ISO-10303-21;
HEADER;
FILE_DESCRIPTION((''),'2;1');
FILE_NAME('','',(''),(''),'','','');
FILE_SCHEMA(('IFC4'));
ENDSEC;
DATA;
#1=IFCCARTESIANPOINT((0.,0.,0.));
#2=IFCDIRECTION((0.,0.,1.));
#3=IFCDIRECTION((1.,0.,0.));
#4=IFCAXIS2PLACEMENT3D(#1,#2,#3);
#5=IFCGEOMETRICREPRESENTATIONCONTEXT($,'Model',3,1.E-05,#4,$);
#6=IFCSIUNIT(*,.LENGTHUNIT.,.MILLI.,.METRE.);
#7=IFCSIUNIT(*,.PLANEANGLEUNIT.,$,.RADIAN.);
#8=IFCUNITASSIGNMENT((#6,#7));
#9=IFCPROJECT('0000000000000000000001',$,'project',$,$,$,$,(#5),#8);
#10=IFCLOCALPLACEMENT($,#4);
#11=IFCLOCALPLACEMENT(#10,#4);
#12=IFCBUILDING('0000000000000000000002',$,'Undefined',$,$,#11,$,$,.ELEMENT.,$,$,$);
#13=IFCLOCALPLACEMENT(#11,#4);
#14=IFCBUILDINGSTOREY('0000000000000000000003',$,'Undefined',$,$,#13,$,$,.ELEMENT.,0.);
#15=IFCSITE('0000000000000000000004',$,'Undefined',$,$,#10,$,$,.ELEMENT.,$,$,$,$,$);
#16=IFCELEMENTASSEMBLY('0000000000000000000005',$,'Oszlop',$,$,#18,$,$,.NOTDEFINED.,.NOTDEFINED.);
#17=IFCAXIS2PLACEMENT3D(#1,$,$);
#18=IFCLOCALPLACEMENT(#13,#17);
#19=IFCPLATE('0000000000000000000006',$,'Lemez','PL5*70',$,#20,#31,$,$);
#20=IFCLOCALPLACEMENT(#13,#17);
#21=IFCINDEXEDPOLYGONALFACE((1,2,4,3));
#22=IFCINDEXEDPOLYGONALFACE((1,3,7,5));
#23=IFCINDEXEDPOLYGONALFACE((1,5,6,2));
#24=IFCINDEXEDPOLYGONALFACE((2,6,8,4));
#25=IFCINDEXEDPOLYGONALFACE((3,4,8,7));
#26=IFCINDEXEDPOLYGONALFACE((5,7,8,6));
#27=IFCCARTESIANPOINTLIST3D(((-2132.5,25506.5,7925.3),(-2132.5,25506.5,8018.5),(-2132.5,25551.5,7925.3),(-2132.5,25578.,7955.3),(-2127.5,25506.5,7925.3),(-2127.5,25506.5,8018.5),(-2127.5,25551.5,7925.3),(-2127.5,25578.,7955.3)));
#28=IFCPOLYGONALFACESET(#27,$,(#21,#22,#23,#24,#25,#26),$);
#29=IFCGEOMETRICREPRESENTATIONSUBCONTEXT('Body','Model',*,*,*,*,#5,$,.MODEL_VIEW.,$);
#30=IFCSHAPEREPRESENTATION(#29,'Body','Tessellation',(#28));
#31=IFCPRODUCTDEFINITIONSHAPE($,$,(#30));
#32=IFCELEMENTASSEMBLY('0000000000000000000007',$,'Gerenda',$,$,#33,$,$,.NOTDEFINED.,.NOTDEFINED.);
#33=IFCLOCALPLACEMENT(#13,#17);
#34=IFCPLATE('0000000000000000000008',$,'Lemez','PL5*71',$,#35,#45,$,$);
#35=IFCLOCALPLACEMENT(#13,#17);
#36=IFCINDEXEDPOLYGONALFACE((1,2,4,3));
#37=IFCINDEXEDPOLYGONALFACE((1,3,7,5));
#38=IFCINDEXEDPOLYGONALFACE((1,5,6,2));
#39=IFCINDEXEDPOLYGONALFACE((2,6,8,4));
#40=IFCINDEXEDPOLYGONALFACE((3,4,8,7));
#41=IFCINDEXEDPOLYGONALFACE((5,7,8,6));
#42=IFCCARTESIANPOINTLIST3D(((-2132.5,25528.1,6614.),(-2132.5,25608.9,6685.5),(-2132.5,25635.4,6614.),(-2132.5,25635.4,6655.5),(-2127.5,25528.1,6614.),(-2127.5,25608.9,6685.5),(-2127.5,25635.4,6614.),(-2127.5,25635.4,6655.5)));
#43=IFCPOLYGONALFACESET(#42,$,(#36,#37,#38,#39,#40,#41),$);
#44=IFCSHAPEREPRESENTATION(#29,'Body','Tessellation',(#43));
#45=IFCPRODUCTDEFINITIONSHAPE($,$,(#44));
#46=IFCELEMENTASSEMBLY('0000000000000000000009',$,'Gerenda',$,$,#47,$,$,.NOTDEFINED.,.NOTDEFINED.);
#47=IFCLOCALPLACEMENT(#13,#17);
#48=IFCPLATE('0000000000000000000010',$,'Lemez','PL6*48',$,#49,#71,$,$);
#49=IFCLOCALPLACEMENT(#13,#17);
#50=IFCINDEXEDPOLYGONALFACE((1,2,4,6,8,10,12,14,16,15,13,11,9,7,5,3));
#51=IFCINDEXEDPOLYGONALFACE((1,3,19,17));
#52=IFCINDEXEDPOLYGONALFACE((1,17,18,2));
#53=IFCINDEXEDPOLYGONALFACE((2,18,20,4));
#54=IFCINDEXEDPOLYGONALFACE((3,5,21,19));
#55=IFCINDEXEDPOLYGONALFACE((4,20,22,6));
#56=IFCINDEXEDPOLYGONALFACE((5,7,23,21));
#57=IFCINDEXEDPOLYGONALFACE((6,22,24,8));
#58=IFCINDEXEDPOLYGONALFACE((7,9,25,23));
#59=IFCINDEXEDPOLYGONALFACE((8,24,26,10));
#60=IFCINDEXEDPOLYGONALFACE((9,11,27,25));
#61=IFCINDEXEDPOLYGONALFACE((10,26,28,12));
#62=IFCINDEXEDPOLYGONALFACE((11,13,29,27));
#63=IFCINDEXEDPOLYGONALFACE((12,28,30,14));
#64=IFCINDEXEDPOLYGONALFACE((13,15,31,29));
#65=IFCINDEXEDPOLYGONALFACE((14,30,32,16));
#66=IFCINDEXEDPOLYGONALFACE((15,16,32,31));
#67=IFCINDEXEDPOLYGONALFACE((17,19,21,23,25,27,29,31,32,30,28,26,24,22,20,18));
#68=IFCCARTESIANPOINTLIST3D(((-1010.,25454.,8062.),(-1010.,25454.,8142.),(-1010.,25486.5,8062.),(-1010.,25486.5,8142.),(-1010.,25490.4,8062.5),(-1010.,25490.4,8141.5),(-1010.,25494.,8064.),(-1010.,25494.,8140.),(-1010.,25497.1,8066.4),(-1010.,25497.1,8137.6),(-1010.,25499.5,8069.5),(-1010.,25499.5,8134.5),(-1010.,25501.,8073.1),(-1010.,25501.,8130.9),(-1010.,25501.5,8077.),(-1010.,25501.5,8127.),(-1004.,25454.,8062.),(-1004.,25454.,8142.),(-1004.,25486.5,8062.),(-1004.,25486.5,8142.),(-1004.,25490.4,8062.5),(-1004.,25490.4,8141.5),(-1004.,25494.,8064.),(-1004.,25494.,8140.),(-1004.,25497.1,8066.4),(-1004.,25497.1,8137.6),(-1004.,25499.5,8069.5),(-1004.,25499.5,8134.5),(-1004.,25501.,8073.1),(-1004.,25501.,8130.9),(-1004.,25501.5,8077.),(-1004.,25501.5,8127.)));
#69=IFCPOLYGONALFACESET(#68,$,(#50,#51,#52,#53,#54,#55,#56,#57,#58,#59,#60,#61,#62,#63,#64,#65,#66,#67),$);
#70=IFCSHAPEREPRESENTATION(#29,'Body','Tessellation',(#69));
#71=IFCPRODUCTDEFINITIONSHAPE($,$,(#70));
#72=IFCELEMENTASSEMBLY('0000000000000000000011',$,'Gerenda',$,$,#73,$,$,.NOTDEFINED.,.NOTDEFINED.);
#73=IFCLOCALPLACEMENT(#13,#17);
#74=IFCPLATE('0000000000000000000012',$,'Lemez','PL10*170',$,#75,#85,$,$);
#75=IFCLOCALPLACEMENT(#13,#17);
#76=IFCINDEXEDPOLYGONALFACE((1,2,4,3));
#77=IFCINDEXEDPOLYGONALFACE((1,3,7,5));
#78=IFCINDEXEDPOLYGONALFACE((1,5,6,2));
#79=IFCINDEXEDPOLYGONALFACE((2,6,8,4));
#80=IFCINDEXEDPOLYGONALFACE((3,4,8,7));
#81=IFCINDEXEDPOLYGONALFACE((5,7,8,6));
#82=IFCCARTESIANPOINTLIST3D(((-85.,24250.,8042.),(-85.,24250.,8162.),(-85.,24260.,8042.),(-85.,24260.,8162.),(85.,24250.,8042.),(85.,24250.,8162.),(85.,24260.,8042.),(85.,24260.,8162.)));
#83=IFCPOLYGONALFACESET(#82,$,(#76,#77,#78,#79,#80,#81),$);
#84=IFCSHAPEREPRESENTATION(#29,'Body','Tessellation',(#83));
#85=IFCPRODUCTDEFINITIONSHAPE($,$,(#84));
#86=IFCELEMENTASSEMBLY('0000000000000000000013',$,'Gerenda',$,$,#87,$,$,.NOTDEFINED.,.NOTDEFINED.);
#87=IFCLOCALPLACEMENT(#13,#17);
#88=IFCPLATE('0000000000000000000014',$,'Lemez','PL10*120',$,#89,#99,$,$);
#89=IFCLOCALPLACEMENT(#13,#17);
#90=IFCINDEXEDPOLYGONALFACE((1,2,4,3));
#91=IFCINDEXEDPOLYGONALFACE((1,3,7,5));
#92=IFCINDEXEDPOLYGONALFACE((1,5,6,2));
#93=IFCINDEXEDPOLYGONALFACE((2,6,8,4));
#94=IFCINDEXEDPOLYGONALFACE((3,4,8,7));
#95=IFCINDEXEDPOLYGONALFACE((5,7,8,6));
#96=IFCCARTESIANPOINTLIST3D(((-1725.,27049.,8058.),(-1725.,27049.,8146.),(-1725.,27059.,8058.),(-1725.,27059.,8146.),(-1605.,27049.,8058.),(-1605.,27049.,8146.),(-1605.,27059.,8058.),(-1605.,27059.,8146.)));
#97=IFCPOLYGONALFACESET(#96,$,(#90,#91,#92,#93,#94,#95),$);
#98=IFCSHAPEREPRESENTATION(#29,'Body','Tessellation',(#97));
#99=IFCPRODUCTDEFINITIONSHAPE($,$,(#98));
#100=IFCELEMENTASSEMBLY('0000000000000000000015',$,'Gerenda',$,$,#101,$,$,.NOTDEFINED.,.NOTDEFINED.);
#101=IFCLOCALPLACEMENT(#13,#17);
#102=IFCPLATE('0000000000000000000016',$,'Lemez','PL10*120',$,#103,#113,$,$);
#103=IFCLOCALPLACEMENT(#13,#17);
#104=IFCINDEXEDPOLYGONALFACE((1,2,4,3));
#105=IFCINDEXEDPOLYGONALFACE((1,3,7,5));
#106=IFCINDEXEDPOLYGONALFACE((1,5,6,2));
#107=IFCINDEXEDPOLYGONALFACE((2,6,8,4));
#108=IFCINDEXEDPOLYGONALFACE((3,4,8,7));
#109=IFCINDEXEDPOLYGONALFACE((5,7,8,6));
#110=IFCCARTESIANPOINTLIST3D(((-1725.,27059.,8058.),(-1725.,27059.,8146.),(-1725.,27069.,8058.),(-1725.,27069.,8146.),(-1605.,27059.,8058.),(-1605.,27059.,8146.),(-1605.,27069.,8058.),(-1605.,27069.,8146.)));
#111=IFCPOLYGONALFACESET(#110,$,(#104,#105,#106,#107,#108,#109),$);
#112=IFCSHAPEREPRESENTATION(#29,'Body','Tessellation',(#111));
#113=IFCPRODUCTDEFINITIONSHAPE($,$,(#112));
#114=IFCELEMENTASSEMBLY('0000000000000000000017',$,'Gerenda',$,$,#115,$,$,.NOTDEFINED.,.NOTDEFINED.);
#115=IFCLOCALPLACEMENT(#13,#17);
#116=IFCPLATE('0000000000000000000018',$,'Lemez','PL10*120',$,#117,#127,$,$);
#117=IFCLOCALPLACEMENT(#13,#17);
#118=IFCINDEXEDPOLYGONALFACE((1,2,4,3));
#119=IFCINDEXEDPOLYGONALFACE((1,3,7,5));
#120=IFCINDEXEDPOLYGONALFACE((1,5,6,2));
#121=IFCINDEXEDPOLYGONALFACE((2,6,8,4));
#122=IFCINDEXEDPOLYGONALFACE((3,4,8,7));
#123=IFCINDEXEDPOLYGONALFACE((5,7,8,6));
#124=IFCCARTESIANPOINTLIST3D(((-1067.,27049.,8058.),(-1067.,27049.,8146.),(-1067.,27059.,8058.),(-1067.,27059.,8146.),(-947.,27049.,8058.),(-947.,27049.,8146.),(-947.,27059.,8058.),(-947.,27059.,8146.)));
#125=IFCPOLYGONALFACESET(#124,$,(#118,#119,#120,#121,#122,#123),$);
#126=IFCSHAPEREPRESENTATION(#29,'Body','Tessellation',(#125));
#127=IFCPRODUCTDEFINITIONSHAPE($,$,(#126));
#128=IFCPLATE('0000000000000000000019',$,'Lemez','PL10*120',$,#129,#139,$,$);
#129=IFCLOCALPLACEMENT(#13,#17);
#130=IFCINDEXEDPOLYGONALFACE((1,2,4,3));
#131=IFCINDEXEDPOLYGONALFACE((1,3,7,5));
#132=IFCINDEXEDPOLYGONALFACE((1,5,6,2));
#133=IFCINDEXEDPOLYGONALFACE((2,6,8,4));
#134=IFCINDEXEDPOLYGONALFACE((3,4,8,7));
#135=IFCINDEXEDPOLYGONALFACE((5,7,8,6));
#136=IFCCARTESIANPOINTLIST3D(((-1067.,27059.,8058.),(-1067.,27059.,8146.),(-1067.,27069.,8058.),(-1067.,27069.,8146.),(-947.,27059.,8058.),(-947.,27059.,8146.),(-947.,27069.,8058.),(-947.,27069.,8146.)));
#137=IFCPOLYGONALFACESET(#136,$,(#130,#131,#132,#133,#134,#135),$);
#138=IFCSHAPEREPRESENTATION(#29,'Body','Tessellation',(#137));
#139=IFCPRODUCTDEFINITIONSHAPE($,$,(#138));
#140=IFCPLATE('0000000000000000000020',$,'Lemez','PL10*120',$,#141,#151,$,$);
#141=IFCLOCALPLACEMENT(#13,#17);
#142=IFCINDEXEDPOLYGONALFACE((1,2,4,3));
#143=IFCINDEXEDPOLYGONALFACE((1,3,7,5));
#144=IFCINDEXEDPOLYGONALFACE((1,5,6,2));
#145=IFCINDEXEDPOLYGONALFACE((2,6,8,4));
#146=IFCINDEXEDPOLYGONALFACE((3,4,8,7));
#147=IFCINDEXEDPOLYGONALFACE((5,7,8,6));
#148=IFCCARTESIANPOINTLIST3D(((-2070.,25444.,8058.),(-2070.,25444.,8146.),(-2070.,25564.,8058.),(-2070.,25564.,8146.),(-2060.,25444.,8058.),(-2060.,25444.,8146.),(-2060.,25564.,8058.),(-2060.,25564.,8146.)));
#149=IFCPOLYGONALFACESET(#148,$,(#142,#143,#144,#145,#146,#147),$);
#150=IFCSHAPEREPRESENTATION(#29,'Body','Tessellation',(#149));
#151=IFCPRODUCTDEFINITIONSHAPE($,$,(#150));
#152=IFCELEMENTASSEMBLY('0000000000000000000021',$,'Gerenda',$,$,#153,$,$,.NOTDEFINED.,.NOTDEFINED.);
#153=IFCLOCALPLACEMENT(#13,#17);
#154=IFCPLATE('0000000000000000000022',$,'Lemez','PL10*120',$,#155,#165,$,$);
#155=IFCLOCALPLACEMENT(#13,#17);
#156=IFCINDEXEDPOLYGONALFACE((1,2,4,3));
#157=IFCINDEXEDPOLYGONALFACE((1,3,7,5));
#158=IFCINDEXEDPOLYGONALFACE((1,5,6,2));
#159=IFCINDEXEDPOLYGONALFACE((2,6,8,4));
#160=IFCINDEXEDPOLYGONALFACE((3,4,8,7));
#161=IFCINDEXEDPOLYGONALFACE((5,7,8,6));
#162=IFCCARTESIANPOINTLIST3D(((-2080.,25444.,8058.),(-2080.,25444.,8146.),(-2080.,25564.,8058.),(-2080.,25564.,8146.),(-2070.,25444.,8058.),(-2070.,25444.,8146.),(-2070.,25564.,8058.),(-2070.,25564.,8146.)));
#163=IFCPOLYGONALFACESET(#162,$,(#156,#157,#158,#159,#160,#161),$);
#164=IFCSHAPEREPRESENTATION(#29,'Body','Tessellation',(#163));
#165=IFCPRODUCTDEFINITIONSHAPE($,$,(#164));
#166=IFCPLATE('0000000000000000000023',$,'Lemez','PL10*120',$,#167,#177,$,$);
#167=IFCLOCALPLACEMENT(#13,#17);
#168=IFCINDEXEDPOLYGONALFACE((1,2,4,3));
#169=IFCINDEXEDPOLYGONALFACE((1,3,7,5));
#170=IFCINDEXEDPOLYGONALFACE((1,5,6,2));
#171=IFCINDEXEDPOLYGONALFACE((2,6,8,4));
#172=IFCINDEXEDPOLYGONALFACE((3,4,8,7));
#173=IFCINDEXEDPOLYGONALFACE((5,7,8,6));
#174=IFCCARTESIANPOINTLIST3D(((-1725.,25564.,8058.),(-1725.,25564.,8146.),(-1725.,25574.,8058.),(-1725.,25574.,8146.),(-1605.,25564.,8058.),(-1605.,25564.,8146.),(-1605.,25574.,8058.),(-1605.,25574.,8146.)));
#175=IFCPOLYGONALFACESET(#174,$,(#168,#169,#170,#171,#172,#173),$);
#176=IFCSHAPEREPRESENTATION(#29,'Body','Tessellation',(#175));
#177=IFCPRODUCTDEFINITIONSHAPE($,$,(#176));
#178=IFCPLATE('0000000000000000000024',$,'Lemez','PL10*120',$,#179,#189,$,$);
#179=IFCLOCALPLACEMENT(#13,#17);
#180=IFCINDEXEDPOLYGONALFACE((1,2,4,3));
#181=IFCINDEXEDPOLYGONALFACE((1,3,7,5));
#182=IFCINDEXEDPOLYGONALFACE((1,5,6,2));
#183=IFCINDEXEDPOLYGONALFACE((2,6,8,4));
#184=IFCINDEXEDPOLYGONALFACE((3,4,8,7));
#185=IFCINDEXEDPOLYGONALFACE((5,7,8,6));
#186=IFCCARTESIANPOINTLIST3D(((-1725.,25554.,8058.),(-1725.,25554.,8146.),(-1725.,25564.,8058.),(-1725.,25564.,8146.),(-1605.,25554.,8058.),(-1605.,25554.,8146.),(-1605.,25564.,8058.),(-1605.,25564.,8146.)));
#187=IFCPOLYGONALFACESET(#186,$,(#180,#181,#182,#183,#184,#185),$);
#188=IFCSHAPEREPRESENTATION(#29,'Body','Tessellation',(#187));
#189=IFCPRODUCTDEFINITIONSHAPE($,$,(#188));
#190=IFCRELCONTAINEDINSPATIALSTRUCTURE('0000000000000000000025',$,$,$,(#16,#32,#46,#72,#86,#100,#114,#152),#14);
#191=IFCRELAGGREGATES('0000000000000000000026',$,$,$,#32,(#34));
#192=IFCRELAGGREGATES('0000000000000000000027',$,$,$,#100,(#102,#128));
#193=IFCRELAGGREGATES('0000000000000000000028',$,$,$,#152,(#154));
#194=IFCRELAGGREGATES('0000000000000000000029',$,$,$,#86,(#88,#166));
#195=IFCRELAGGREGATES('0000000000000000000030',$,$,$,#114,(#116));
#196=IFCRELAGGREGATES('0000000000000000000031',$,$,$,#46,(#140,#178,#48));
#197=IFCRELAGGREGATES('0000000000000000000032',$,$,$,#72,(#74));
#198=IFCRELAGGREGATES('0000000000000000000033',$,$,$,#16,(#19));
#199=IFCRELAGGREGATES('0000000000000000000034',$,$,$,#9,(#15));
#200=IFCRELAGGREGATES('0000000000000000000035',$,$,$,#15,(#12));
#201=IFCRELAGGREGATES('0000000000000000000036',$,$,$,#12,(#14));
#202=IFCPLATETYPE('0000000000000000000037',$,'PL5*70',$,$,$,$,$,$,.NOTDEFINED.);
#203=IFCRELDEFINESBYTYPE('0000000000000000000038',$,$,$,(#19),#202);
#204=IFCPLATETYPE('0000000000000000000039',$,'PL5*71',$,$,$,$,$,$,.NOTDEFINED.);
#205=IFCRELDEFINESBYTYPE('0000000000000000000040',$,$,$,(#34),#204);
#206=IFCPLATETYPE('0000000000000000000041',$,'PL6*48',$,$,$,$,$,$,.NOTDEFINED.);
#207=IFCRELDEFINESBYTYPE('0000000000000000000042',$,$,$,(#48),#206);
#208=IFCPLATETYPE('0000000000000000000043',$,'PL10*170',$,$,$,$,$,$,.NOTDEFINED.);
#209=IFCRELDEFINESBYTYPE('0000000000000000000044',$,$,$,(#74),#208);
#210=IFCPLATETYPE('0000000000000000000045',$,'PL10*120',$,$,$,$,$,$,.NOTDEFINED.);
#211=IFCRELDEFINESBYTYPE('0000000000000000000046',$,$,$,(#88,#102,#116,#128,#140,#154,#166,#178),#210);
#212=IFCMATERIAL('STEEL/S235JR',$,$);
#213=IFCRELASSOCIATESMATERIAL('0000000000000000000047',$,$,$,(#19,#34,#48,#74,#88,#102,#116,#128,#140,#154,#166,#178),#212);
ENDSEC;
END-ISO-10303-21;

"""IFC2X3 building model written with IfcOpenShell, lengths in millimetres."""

from ifc_helpers import new_model, si_unit, frame, frame_2d, origin_with_axes, place, context, subcontext, project, spatial, polyline, circle_curve, parameter, trimmed, segment, composite_curve, outline, extrude, material, type_object, element, aggregate, save


model = new_model("IFC2X3")

# Units and contexts
model_context = context("Model", 3, precision=1e-05, world=origin_with_axes())
body_context = subcontext(model_context, "Body", "Model", "MODEL_VIEW")
ifc_project = project(units=[si_unit("LENGTHUNIT", "METRE", prefix="MILLI"), si_unit("PLANEANGLEUNIT", "RADIAN")], contexts=[model_context])

# Site, building, storey
site_placement = place(None, origin_with_axes())
site = spatial("IfcSite", under=ifc_project, at=site_placement, Name="Undefined", CompositionType="ELEMENT")
building_placement = place(site_placement, origin_with_axes())
building = spatial("IfcBuilding", under=site, at=building_placement, Name="Undefined", CompositionType="ELEMENT")
storey_placement = place(building_placement, origin_with_axes())
storey = spatial("IfcBuildingStorey", under=building, at=storey_placement, Name="Undefined", CompositionType="ELEMENT", Elevation=0.0)

# Shared definitions
ifc_material_1 = material(Name="STEEL/S235JR")

# Element assemblies, plates
assembly_1_placement = place(storey_placement, origin_with_axes())
assembly_1 = element("IfcElementAssembly", 1, at=assembly_1_placement, inside=storey, Name="Oszlop", AssemblyPlace="NOTDEFINED", PredefinedType="NOTDEFINED")
plate_type_1 = type_object("IfcPlateType", Name="PL5*70", PredefinedType="NOTDEFINED")
plate_1_placement = place(assembly_1_placement, frame((-2130.0, 25506.5, 7925.3), z_axis=(-1.0, -0.000005, 0.0), x_axis=(0.0, 0.0, 1.0)))
plate_1 = element("IfcPlate", 2, at=plate_1_placement, type_object=plate_type_1, material=ifc_material_1, Name="Lemez", Description="PL5*70", context=body_context, shape_type="SweptSolid", body=[
    extrude(outline(polyline([(0.0, 0.0), (93.2, 0.0), (30.0, 71.5), (0.0, 45.0), (0.0, 0.0)])), frame((0.0, 0.0, -2.5), z_axis=(0.0, 0.0, 1.0), x_axis=(1.0, 0.0, 0.0)), (0.0, 0.0, 1.0), 5.0),
])
assembly_2_placement = place(storey_placement, origin_with_axes())
assembly_2 = element("IfcElementAssembly", 3, at=assembly_2_placement, inside=storey, Name="Gerenda", AssemblyPlace="NOTDEFINED", PredefinedType="NOTDEFINED")
plate_type_2 = type_object("IfcPlateType", Name="PL5*71", PredefinedType="NOTDEFINED")
plate_2_placement = place(assembly_2_placement, frame((-2130.0, 25528.1, 6614.0), z_axis=(1.0, -0.000003, -0.000002), x_axis=(0.000003, 1.0, 0.0)))
plate_2 = element("IfcPlate", 4, at=plate_2_placement, type_object=plate_type_2, material=ifc_material_1, Name="Lemez", Description="PL5*71", context=body_context, shape_type="SweptSolid", body=[
    extrude(outline(polyline([(0.0, 0.0), (107.3, 0.0), (107.3, 41.5), (80.8, 71.5), (0.0, 0.0)])), frame((0.0, 0.0, -2.5), z_axis=(0.0, 0.0, 1.0), x_axis=(1.0, 0.0, 0.0)), (0.0, 0.0, 1.0), 5.0),
])
aggregate(assembly_2, [plate_2])
assembly_3_placement = place(storey_placement, origin_with_axes())
assembly_3 = element("IfcElementAssembly", 5, at=assembly_3_placement, inside=storey, Name="Gerenda", AssemblyPlace="NOTDEFINED", PredefinedType="NOTDEFINED")
plate_type_3 = type_object("IfcPlateType", Name="PL6*48", PredefinedType="NOTDEFINED")
plate_3_placement = place(assembly_3_placement, frame((-1007.0, 25501.5, 8062.0), z_axis=(-1.0, 0.000003, 0.0), x_axis=(-0.000003, -1.0, 0.0)))
plate_3 = element("IfcPlate", 6, at=plate_3_placement, type_object=plate_type_3, material=ifc_material_1, Name="Lemez", Description="PL6*48", context=body_context, shape_type="SweptSolid", body=[
    extrude(outline(composite_curve([segment(trimmed(circle_curve(frame_2d((15.0, 15.0), x_axis=(-1.0, 0.0)), 15.0), [parameter(0.0)], [parameter(1.570796)], True, "PARAMETER"), True, "CONTINUOUS"), segment(polyline([(15.0, 0.0), (47.5, 0.0), (47.5, 80.0), (15.0, 80.0)]), True, "CONTINUOUS"), segment(trimmed(circle_curve(frame_2d((15.0, 65.0), x_axis=(0.0, 1.0)), 15.0), [parameter(0.0)], [parameter(1.570796)], True, "PARAMETER"), True, "CONTINUOUS"), segment(polyline([(0.0, 65.0), (0.0, 15.0)]), True, "CONTINUOUS")], self_intersect=True)), frame((0.0, 0.0, -3.0), z_axis=(0.0, 0.0, 1.0), x_axis=(1.0, 0.0, 0.0)), (0.0, 0.0, 1.0), 6.0),
])
assembly_4_placement = place(storey_placement, origin_with_axes())
assembly_4 = element("IfcElementAssembly", 7, at=assembly_4_placement, inside=storey, Name="Gerenda", AssemblyPlace="NOTDEFINED", PredefinedType="NOTDEFINED")
plate_type_4 = type_object("IfcPlateType", Name="PL10*170", PredefinedType="NOTDEFINED")
plate_4_placement = place(assembly_4_placement, frame((0.0, 24255.0, 8042.0), z_axis=(0.000003, 1.0, 0.0), x_axis=(0.0, 0.0, 1.0)))
plate_4 = element("IfcPlate", 8, at=plate_4_placement, type_object=plate_type_4, material=ifc_material_1, Name="Lemez", Description="PL10*170", context=body_context, shape_type="SweptSolid", body=[
    extrude(outline(polyline([(0.0, -85.0), (0.0, 85.0), (120.0, 85.0), (120.0, -85.0), (0.0, -85.0)])), frame((0.0, 0.0, -5.0), z_axis=(0.0, 0.0, 1.0), x_axis=(1.0, 0.0, 0.0)), (0.0, 0.0, 1.0), 10.0),
])
assembly_5_placement = place(storey_placement, origin_with_axes())
assembly_5 = element("IfcElementAssembly", 9, at=assembly_5_placement, inside=storey, Name="Gerenda", AssemblyPlace="NOTDEFINED", PredefinedType="NOTDEFINED")
plate_type_5 = type_object("IfcPlateType", Name="PL10*120", PredefinedType="NOTDEFINED")
plate_5_placement = place(assembly_5_placement, frame((-1665.0, 27054.0, 8058.0), z_axis=(-0.000003, -1.0, 0.0), x_axis=(0.0, 0.0, 1.0)))
plate_5 = element("IfcPlate", 10, at=plate_5_placement, type_object=plate_type_5, material=ifc_material_1, Name="Lemez", Description="PL10*120", context=body_context, shape_type="SweptSolid", body=[
    extrude(outline(polyline([(0.0, -60.0), (0.0, 60.0), (88.0, 60.0), (88.0, -60.0), (0.0, -60.0)])), frame((0.0, 0.0, -5.0), z_axis=(0.0, 0.0, 1.0), x_axis=(1.0, 0.0, 0.0)), (0.0, 0.0, 1.0), 10.0),
])
assembly_6_placement = place(storey_placement, origin_with_axes())
assembly_6 = element("IfcElementAssembly", 11, at=assembly_6_placement, inside=storey, Name="Gerenda", AssemblyPlace="NOTDEFINED", PredefinedType="NOTDEFINED")
plate_6_placement = place(assembly_6_placement, frame((-1665.0, 27064.0, 8058.0), z_axis=(-0.000003, -1.0, 0.0), x_axis=(0.0, 0.0, 1.0)))
plate_6 = element("IfcPlate", 12, at=plate_6_placement, type_object=plate_type_5, material=ifc_material_1, Name="Lemez", Description="PL10*120", context=body_context, shape_type="SweptSolid", body=[
    extrude(outline(polyline([(0.0, -60.0), (0.0, 60.0), (88.0, 60.0), (88.0, -60.0), (0.0, -60.0)])), frame((0.0, 0.0, -5.0), z_axis=(0.0, 0.0, 1.0), x_axis=(1.0, 0.0, 0.0)), (0.0, 0.0, 1.0), 10.0),
])
assembly_7_placement = place(storey_placement, origin_with_axes())
assembly_7 = element("IfcElementAssembly", 13, at=assembly_7_placement, inside=storey, Name="Gerenda", AssemblyPlace="NOTDEFINED", PredefinedType="NOTDEFINED")
plate_7_placement = place(assembly_7_placement, frame((-1007.0, 27054.0, 8058.0), z_axis=(-0.000003, -1.0, 0.0), x_axis=(0.0, 0.0, 1.0)))
plate_7 = element("IfcPlate", 14, at=plate_7_placement, type_object=plate_type_5, material=ifc_material_1, Name="Lemez", Description="PL10*120", context=body_context, shape_type="SweptSolid", body=[
    extrude(outline(polyline([(0.0, -60.0), (0.0, 60.0), (88.0, 60.0), (88.0, -60.0), (0.0, -60.0)])), frame((0.0, 0.0, -5.0), z_axis=(0.0, 0.0, 1.0), x_axis=(1.0, 0.0, 0.0)), (0.0, 0.0, 1.0), 10.0),
])

# Plates
plate_8_placement = place(assembly_6_placement, frame((-1007.0, 27064.0, 8058.0), z_axis=(-0.000003, -1.0, 0.0), x_axis=(0.0, 0.0, 1.0)))
plate_8 = element("IfcPlate", 15, at=plate_8_placement, type_object=plate_type_5, material=ifc_material_1, Name="Lemez", Description="PL10*120", context=body_context, shape_type="SweptSolid", body=[
    extrude(outline(polyline([(0.0, -60.0), (0.0, 60.0), (88.0, 60.0), (88.0, -60.0), (0.0, -60.0)])), frame((0.0, 0.0, -5.0), z_axis=(0.0, 0.0, 1.0), x_axis=(1.0, 0.0, 0.0)), (0.0, 0.0, 1.0), 10.0),
])
aggregate(assembly_6, [plate_6, plate_8])
plate_9_placement = place(assembly_3_placement, frame((-2065.0, 25504.0, 8058.0), z_axis=(1.0, -0.000004, 0.0), x_axis=(0.0, 0.0, 1.0)))
plate_9 = element("IfcPlate", 16, at=plate_9_placement, type_object=plate_type_5, material=ifc_material_1, Name="Lemez", Description="PL10*120", context=body_context, shape_type="SweptSolid", body=[
    extrude(outline(polyline([(0.0, -60.0), (0.0, 60.0), (88.0, 60.0), (88.0, -60.0), (0.0, -60.0)])), frame((0.0, 0.0, -5.0), z_axis=(0.0, 0.0, 1.0), x_axis=(1.0, 0.0, 0.0)), (0.0, 0.0, 1.0), 10.0),
])

# Element assembly, plate
assembly_8_placement = place(storey_placement, origin_with_axes())
assembly_8 = element("IfcElementAssembly", 17, at=assembly_8_placement, inside=storey, Name="Gerenda", AssemblyPlace="NOTDEFINED", PredefinedType="NOTDEFINED")
plate_10_placement = place(assembly_8_placement, frame((-2075.0, 25504.0, 8058.0), z_axis=(1.0, -0.000004, 0.0), x_axis=(0.0, 0.0, 1.0)))
plate_10 = element("IfcPlate", 18, at=plate_10_placement, type_object=plate_type_5, material=ifc_material_1, Name="Lemez", Description="PL10*120", context=body_context, shape_type="SweptSolid", body=[
    extrude(outline(polyline([(0.0, -60.0), (0.0, 60.0), (88.0, 60.0), (88.0, -60.0), (0.0, -60.0)])), frame((0.0, 0.0, -5.0), z_axis=(0.0, 0.0, 1.0), x_axis=(1.0, 0.0, 0.0)), (0.0, 0.0, 1.0), 10.0),
])
aggregate(assembly_8, [plate_10])

# Plates
plate_11_placement = place(assembly_5_placement, frame((-1665.0, 25569.0, 8058.0), z_axis=(0.000003, 1.0, 0.0), x_axis=(0.0, 0.0, 1.0)))
plate_11 = element("IfcPlate", 19, at=plate_11_placement, type_object=plate_type_5, material=ifc_material_1, Name="Lemez", Description="PL10*120", context=body_context, shape_type="SweptSolid", body=[
    extrude(outline(polyline([(0.0, -60.0), (0.0, 60.0), (88.0, 60.0), (88.0, -60.0), (0.0, -60.0)])), frame((0.0, 0.0, -5.0), z_axis=(0.0, 0.0, 1.0), x_axis=(1.0, 0.0, 0.0)), (0.0, 0.0, 1.0), 10.0),
])
aggregate(assembly_5, [plate_5, plate_11])
plate_12_placement = place(assembly_3_placement, frame((-1665.0, 25559.0, 8058.0), z_axis=(0.000003, 1.0, 0.0), x_axis=(0.0, 0.0, 1.0)))
plate_12 = element("IfcPlate", 20, at=plate_12_placement, type_object=plate_type_5, material=ifc_material_1, Name="Lemez", Description="PL10*120", context=body_context, shape_type="SweptSolid", body=[
    extrude(outline(polyline([(0.0, -60.0), (0.0, 60.0), (88.0, 60.0), (88.0, -60.0), (0.0, -60.0)])), frame((0.0, 0.0, -5.0), z_axis=(0.0, 0.0, 1.0), x_axis=(1.0, 0.0, 0.0)), (0.0, 0.0, 1.0), 10.0),
])
aggregate(assembly_7, [plate_7])
aggregate(assembly_3, [plate_9, plate_12, plate_3])
aggregate(assembly_4, [plate_4])

aggregate(assembly_1, [plate_1])

save(model, "model.ifc")
